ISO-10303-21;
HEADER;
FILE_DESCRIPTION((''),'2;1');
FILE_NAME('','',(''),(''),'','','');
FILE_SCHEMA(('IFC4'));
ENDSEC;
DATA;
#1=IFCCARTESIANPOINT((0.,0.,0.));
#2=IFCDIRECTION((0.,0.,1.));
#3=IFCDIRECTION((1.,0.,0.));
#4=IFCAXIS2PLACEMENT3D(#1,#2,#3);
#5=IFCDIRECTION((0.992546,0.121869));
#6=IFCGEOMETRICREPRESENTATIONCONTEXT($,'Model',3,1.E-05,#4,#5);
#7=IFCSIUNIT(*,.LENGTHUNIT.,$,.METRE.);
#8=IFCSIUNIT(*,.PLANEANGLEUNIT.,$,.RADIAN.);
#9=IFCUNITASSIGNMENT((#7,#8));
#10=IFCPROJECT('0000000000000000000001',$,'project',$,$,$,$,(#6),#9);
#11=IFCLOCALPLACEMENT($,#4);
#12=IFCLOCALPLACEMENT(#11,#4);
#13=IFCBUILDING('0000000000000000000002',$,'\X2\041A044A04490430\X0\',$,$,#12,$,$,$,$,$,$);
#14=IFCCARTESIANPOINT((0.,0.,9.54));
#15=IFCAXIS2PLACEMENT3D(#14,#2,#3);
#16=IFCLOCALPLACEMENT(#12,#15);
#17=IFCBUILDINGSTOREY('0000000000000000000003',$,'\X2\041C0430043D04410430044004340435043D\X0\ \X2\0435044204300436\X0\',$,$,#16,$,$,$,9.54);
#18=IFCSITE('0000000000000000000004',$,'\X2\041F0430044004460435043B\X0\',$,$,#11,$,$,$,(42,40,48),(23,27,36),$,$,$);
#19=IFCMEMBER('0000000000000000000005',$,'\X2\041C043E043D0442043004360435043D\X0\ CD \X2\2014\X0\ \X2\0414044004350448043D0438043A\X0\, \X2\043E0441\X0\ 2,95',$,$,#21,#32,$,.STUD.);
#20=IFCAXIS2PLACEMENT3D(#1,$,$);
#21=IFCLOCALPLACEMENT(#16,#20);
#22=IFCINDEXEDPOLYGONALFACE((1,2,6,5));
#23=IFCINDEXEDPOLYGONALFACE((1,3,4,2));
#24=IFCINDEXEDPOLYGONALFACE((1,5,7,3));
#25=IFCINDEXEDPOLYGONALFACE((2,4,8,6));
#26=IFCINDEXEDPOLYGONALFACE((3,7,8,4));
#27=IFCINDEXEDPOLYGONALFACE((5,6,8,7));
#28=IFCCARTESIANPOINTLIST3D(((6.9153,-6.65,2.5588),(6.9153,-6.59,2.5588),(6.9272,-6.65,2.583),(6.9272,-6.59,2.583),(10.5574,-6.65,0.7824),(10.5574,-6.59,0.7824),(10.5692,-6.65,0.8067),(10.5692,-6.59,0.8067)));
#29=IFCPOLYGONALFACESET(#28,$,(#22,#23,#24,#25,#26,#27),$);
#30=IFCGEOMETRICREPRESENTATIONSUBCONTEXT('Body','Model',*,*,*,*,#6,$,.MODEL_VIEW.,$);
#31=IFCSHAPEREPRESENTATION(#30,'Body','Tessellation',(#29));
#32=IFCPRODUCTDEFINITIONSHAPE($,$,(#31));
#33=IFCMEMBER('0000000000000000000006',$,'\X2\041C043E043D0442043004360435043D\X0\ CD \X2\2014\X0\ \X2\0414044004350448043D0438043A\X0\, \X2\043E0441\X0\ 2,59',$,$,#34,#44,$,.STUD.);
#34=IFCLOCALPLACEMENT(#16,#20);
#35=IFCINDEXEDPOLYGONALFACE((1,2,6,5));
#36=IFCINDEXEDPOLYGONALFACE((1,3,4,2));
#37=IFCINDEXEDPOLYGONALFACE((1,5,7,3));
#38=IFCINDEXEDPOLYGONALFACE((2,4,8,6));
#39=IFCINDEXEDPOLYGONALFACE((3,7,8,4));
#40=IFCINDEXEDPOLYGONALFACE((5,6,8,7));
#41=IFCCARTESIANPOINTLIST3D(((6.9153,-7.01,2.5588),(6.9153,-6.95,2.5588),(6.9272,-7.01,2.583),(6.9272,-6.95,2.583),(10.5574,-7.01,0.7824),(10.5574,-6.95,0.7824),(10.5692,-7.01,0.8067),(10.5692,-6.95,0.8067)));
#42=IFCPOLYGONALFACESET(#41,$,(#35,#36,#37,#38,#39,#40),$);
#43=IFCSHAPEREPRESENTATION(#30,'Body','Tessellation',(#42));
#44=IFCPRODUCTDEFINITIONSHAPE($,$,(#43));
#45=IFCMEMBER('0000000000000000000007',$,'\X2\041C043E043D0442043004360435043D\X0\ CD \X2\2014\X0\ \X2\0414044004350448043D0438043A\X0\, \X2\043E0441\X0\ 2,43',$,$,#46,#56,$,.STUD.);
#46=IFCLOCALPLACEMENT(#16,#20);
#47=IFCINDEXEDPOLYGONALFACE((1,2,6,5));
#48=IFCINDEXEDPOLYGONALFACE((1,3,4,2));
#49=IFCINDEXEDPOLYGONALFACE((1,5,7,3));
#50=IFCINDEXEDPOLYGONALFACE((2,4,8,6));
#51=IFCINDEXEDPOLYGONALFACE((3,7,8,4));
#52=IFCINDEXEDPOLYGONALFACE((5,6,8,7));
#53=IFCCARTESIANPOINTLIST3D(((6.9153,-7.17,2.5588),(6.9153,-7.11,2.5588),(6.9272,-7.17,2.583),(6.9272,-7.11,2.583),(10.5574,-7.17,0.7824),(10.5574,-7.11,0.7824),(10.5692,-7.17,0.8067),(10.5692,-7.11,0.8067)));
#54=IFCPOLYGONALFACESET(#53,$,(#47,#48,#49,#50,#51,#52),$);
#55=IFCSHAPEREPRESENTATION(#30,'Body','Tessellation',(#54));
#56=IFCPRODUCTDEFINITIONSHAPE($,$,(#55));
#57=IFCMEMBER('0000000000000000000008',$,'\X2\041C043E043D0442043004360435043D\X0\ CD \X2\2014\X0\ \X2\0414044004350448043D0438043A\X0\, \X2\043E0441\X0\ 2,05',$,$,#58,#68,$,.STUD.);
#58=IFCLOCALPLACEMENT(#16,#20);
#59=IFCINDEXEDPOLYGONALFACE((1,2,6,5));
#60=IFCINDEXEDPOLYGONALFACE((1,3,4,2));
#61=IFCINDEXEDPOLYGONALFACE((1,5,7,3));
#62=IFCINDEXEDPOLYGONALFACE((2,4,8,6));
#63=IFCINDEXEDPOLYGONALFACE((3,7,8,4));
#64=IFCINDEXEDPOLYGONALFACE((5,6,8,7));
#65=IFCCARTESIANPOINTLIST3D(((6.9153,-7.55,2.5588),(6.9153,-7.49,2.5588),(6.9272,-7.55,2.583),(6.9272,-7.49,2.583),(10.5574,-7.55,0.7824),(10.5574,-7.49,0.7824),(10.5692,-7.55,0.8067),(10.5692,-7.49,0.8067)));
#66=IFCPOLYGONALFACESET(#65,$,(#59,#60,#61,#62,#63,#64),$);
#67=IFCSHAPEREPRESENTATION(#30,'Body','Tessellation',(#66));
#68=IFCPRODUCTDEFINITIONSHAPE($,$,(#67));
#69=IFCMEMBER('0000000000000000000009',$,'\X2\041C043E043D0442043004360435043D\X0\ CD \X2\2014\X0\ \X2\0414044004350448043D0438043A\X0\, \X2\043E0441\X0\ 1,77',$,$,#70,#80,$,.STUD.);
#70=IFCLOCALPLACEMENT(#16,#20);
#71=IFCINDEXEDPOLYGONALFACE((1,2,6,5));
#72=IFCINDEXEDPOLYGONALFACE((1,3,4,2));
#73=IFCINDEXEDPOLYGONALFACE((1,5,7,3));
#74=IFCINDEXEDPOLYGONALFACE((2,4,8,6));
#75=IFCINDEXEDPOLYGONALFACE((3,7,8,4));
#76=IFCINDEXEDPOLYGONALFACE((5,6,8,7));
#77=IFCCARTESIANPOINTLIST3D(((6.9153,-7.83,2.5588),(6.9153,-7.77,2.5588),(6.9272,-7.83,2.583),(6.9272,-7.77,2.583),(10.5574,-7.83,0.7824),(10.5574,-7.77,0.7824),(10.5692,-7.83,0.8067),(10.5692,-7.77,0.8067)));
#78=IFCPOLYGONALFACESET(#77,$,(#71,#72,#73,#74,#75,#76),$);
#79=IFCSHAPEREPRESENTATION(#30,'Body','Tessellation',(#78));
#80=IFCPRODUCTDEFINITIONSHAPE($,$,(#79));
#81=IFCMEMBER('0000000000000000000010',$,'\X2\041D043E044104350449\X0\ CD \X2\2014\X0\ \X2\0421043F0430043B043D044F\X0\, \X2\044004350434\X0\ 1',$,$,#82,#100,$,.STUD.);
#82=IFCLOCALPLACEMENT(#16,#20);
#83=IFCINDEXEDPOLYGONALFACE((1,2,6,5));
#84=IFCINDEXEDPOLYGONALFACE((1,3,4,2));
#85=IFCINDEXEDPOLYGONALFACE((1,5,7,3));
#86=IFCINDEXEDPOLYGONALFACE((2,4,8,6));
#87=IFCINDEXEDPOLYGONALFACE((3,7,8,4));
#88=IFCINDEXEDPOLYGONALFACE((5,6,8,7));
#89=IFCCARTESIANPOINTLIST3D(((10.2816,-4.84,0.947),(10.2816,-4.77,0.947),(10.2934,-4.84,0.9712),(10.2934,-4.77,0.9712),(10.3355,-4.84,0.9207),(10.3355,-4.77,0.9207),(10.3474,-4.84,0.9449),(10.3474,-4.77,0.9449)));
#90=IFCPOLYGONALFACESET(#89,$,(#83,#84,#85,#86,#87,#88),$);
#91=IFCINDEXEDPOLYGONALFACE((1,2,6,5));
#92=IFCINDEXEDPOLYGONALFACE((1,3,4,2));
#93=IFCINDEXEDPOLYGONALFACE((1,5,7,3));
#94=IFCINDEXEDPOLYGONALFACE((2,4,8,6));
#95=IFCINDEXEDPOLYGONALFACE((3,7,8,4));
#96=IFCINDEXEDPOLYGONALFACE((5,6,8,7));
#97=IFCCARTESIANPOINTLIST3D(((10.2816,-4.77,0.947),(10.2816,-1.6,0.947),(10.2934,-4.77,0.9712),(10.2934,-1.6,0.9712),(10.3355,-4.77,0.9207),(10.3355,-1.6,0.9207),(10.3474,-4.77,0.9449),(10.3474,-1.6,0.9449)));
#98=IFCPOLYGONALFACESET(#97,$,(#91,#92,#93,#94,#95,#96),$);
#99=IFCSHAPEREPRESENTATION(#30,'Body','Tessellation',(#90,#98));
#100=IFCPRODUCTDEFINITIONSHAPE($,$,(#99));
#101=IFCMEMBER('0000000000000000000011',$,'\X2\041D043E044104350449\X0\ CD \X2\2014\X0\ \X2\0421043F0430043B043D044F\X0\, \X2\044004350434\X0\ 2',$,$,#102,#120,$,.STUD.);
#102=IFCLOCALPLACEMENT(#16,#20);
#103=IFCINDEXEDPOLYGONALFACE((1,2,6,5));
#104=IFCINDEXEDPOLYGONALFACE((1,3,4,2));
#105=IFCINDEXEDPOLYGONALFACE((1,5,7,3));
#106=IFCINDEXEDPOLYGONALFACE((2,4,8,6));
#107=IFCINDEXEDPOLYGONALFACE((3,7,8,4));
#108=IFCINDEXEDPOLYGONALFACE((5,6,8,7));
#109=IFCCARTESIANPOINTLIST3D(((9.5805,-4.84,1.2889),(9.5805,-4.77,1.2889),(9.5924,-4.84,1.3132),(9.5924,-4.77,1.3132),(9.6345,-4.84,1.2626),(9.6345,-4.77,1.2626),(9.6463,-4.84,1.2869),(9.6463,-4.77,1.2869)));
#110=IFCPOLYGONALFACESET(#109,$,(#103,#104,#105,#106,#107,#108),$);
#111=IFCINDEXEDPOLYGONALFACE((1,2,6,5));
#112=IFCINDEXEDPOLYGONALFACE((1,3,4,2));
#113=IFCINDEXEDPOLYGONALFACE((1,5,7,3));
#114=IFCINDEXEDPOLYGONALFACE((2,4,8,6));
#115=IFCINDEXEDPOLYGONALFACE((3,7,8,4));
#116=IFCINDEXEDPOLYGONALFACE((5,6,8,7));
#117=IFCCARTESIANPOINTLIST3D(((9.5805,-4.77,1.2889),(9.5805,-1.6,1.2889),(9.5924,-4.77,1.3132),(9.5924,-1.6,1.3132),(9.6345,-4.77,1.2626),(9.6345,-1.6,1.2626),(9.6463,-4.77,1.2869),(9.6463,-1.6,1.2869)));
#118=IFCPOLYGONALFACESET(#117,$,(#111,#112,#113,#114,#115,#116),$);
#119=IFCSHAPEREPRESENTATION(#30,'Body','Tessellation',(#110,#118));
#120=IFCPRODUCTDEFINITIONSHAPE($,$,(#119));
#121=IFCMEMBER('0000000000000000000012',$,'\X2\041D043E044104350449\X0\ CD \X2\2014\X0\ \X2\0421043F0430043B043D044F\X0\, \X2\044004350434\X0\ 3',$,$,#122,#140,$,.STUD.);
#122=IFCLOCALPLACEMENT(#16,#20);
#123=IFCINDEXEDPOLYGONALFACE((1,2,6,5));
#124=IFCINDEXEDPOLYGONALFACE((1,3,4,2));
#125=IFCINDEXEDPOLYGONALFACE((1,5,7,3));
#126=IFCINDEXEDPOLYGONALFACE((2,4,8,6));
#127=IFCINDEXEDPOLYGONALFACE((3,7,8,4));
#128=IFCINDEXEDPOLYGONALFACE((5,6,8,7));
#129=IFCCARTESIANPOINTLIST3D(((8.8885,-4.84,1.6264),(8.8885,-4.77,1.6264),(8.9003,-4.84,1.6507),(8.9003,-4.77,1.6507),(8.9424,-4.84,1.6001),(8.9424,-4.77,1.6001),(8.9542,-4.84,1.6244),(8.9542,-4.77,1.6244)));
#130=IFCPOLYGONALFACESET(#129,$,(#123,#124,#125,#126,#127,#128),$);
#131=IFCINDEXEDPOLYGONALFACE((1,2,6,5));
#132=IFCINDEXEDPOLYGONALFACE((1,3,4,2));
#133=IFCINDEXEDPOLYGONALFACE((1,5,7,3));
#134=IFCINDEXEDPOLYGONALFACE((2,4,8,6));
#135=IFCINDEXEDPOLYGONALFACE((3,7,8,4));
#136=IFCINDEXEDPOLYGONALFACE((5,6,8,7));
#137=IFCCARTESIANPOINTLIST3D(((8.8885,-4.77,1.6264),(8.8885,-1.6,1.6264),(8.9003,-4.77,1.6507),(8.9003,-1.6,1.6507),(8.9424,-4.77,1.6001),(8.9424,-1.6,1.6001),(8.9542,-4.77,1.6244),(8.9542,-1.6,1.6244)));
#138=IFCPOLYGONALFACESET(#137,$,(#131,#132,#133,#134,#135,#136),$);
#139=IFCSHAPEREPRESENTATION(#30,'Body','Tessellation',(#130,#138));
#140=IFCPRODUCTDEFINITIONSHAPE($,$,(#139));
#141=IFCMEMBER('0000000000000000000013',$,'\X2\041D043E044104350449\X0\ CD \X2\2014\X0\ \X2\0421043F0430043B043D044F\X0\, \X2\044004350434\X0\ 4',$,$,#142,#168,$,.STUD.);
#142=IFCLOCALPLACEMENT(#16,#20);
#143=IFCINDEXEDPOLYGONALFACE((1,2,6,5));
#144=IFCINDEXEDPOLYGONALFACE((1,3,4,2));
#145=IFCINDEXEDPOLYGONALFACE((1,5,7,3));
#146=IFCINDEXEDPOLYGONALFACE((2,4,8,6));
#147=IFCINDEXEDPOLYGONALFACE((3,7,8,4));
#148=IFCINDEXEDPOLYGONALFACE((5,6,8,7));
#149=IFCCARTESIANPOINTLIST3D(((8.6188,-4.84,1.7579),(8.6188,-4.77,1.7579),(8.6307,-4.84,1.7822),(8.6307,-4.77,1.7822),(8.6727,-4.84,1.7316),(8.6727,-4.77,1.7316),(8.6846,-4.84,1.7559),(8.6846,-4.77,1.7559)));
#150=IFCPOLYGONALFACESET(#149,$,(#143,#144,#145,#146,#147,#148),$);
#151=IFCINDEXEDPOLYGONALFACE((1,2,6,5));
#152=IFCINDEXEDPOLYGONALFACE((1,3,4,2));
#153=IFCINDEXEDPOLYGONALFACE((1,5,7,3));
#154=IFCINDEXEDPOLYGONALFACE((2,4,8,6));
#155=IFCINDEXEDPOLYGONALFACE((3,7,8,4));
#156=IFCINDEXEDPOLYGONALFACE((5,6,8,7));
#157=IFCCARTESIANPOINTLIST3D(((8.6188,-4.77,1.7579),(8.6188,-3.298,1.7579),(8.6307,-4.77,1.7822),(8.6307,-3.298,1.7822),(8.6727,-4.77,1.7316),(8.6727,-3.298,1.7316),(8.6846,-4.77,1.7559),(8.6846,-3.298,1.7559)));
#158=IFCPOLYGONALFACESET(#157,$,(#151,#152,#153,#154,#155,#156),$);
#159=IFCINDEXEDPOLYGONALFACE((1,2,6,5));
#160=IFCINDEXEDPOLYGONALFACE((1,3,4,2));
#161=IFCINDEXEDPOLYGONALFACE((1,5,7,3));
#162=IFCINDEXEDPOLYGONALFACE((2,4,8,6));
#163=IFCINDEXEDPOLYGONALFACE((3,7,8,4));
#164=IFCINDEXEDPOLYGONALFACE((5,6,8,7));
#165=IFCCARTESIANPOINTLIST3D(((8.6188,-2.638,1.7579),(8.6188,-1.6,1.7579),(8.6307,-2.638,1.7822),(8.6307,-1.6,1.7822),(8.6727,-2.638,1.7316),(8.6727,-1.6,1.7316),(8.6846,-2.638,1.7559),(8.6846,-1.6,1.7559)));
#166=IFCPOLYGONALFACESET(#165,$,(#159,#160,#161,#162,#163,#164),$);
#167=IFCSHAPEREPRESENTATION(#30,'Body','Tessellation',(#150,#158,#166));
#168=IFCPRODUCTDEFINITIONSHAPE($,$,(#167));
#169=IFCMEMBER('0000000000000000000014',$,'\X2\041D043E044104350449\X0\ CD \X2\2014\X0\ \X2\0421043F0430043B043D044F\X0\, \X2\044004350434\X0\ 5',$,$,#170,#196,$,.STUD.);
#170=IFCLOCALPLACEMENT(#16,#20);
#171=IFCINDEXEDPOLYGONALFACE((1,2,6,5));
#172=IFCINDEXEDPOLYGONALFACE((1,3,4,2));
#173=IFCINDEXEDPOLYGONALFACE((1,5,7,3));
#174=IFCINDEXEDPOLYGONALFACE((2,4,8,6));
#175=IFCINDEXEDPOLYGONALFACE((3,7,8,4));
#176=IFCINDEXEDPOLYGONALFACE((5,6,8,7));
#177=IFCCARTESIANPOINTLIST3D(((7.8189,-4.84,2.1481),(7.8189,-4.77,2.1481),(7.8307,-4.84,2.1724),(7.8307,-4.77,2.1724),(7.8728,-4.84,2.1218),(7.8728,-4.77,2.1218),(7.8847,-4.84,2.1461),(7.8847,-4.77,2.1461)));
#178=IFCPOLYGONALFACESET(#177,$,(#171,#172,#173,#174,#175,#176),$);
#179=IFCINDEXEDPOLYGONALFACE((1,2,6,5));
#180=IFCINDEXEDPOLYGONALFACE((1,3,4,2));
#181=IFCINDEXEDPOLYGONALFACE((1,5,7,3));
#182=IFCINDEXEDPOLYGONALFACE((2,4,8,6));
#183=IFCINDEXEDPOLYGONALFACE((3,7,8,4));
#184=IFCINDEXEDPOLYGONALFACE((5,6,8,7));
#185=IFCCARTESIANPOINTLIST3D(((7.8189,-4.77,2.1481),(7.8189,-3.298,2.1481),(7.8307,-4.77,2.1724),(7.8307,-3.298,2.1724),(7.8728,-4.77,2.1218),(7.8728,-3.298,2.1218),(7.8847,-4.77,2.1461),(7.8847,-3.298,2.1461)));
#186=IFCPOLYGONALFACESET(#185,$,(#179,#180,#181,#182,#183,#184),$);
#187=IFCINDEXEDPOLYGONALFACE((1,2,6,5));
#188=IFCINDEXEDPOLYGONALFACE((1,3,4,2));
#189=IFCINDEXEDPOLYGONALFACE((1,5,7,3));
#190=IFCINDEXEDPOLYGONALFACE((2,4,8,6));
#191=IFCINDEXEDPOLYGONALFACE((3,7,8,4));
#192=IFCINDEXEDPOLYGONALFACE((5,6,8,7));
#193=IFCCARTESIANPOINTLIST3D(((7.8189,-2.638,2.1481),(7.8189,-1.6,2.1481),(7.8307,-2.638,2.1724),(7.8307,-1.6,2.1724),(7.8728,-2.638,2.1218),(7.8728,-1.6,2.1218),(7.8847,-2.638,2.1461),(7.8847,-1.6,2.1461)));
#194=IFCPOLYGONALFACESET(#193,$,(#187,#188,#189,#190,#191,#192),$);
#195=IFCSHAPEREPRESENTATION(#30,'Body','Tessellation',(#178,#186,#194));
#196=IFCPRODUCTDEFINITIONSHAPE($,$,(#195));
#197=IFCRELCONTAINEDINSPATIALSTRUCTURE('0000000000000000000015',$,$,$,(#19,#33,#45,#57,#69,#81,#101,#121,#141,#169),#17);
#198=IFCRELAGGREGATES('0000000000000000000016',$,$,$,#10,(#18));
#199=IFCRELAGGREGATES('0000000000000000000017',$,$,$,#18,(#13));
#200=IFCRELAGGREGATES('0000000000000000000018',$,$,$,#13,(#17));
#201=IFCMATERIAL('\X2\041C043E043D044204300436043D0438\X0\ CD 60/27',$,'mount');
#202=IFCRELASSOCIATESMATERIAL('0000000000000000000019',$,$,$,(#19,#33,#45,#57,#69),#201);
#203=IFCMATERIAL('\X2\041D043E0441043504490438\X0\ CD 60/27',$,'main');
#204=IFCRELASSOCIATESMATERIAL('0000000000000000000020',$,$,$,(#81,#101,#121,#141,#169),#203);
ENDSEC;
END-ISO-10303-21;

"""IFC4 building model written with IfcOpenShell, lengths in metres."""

from ifc_helpers import new_model, si_unit, direction, frame, origin_with_axes, place, context, subcontext, project, spatial, polyline, outline, extrude, material, element, save


model = new_model("IFC4")

# Units and contexts
model_context = context("Model", 3, precision=1e-05, world=origin_with_axes(), true_north=direction((0.992546, 0.121869)))
body_context = subcontext(model_context, "Body", "Model", "MODEL_VIEW")
ifc_project = project(units=[si_unit("LENGTHUNIT", "METRE"), si_unit("PLANEANGLEUNIT", "RADIAN")], contexts=[model_context])

# Site, building, storey
site_placement = place(None, origin_with_axes())
site = spatial("IfcSite", under=ifc_project, at=site_placement, Name="Парцел", RefLatitude=(42, 40, 48), RefLongitude=(23, 27, 36))
building_placement = place(site_placement, origin_with_axes())
building = spatial("IfcBuilding", under=site, at=building_placement, Name="Къща")
storey_placement = place(building_placement, frame((0.0, 0.0, 9.54), z_axis=(0.0, 0.0, 1.0), x_axis=(1.0, 0.0, 0.0)))
storey = spatial("IfcBuildingStorey", under=building, at=storey_placement, Name="Мансарден етаж", Elevation=9.54)

# Members
ifc_material_1 = material(Name="Монтажни CD 60/27", Category="mount")
member_1_placement = place(storey_placement, origin_with_axes())
element("IfcMember", 1, at=member_1_placement, inside=storey, material=ifc_material_1, Name="Монтажен CD — Дрешник, ос 2,95", PredefinedType="STUD", context=body_context, shape_type="SweptSolid", body=[
    extrude(outline(polyline([(10.5574, -0.7824), (6.9153, -2.5587), (6.9272, -2.583), (10.5692, -0.8067), (10.5574, -0.7824)])), frame((0.0, -6.65, 0.0), z_axis=(0.0, 1.0, 0.0), x_axis=(1.0, 0.0, 0.0)), (0.0, 0.0, 1.0), 0.06),
])
member_2_placement = place(storey_placement, origin_with_axes())
element("IfcMember", 2, at=member_2_placement, inside=storey, material=ifc_material_1, Name="Монтажен CD — Дрешник, ос 2,59", PredefinedType="STUD", context=body_context, shape_type="SweptSolid", body=[
    extrude(outline(polyline([(10.5574, -0.7824), (6.9153, -2.5587), (6.9272, -2.583), (10.5692, -0.8067), (10.5574, -0.7824)])), frame((0.0, -7.01, 0.0), z_axis=(0.0, 1.0, 0.0), x_axis=(1.0, 0.0, 0.0)), (0.0, 0.0, 1.0), 0.06),
])
member_3_placement = place(storey_placement, origin_with_axes())
element("IfcMember", 3, at=member_3_placement, inside=storey, material=ifc_material_1, Name="Монтажен CD — Дрешник, ос 2,43", PredefinedType="STUD", context=body_context, shape_type="SweptSolid", body=[
    extrude(outline(polyline([(10.5574, -0.7824), (6.9153, -2.5587), (6.9272, -2.583), (10.5692, -0.8067), (10.5574, -0.7824)])), frame((0.0, -7.17, 0.0), z_axis=(0.0, 1.0, 0.0), x_axis=(1.0, 0.0, 0.0)), (0.0, 0.0, 1.0), 0.06),
])
member_4_placement = place(storey_placement, origin_with_axes())
element("IfcMember", 4, at=member_4_placement, inside=storey, material=ifc_material_1, Name="Монтажен CD — Дрешник, ос 2,05", PredefinedType="STUD", context=body_context, shape_type="SweptSolid", body=[
    extrude(outline(polyline([(10.5574, -0.7824), (6.9153, -2.5587), (6.9272, -2.583), (10.5692, -0.8067), (10.5574, -0.7824)])), frame((0.0, -7.55, 0.0), z_axis=(0.0, 1.0, 0.0), x_axis=(1.0, 0.0, 0.0)), (0.0, 0.0, 1.0), 0.06),
])
member_5_placement = place(storey_placement, origin_with_axes())
element("IfcMember", 5, at=member_5_placement, inside=storey, material=ifc_material_1, Name="Монтажен CD — Дрешник, ос 1,77", PredefinedType="STUD", context=body_context, shape_type="SweptSolid", body=[
    extrude(outline(polyline([(10.5574, -0.7824), (6.9153, -2.5587), (6.9272, -2.583), (10.5692, -0.8067), (10.5574, -0.7824)])), frame((0.0, -7.83, 0.0), z_axis=(0.0, 1.0, 0.0), x_axis=(1.0, 0.0, 0.0)), (0.0, 0.0, 1.0), 0.06),
])
ifc_material_2 = material(Name="Носещи CD 60/27", Category="main")
member_6_placement = place(storey_placement, origin_with_axes())
element("IfcMember", 6, at=member_6_placement, inside=storey, material=ifc_material_2, Name="Носещ CD — Спалня, ред 1", PredefinedType="STUD", context=body_context, shape_type="SweptSolid", body=[
    extrude(outline(polyline([(10.3355, -0.9207), (10.2816, -0.947), (10.2934, -0.9712), (10.3474, -0.9449), (10.3355, -0.9207)])), frame((0.0, -4.84, 0.0), z_axis=(0.0, 1.0, 0.0), x_axis=(1.0, 0.0, 0.0)), (0.0, 0.0, 1.0), 0.07),
    extrude(outline(polyline([(10.3355, -0.9207), (10.2816, -0.947), (10.2934, -0.9712), (10.3474, -0.9449), (10.3355, -0.9207)])), frame((0.0, -4.77, 0.0), z_axis=(0.0, 1.0, 0.0), x_axis=(1.0, 0.0, 0.0)), (0.0, 0.0, 1.0), 3.17),
])
member_7_placement = place(storey_placement, origin_with_axes())
element("IfcMember", 7, at=member_7_placement, inside=storey, material=ifc_material_2, Name="Носещ CD — Спалня, ред 2", PredefinedType="STUD", context=body_context, shape_type="SweptSolid", body=[
    extrude(outline(polyline([(9.6345, -1.2626), (9.5805, -1.2889), (9.5924, -1.3132), (9.6463, -1.2869), (9.6345, -1.2626)])), frame((0.0, -4.84, 0.0), z_axis=(0.0, 1.0, 0.0), x_axis=(1.0, 0.0, 0.0)), (0.0, 0.0, 1.0), 0.07),
    extrude(outline(polyline([(9.6345, -1.2626), (9.5805, -1.2889), (9.5924, -1.3132), (9.6463, -1.2869), (9.6345, -1.2626)])), frame((0.0, -4.77, 0.0), z_axis=(0.0, 1.0, 0.0), x_axis=(1.0, 0.0, 0.0)), (0.0, 0.0, 1.0), 3.17),
])
member_8_placement = place(storey_placement, origin_with_axes())
element("IfcMember", 8, at=member_8_placement, inside=storey, material=ifc_material_2, Name="Носещ CD — Спалня, ред 3", PredefinedType="STUD", context=body_context, shape_type="SweptSolid", body=[
    extrude(outline(polyline([(8.9424, -1.6001), (8.8885, -1.6264), (8.9003, -1.6507), (8.9542, -1.6244), (8.9424, -1.6001)])), frame((0.0, -4.84, 0.0), z_axis=(0.0, 1.0, 0.0), x_axis=(1.0, 0.0, 0.0)), (0.0, 0.0, 1.0), 0.07),
    extrude(outline(polyline([(8.9424, -1.6001), (8.8885, -1.6264), (8.9003, -1.6507), (8.9542, -1.6244), (8.9424, -1.6001)])), frame((0.0, -4.77, 0.0), z_axis=(0.0, 1.0, 0.0), x_axis=(1.0, 0.0, 0.0)), (0.0, 0.0, 1.0), 3.17),
])
member_9_placement = place(storey_placement, origin_with_axes())
element("IfcMember", 9, at=member_9_placement, inside=storey, material=ifc_material_2, Name="Носещ CD — Спалня, ред 4", PredefinedType="STUD", context=body_context, shape_type="SweptSolid", body=[
    extrude(outline(polyline([(8.6727, -1.7316), (8.6188, -1.7579), (8.6307, -1.7822), (8.6846, -1.7559), (8.6727, -1.7316)])), frame((0.0, -4.84, 0.0), z_axis=(0.0, 1.0, 0.0), x_axis=(1.0, 0.0, 0.0)), (0.0, 0.0, 1.0), 0.07),
    extrude(outline(polyline([(8.6727, -1.7316), (8.6188, -1.7579), (8.6307, -1.7822), (8.6846, -1.7559), (8.6727, -1.7316)])), frame((0.0, -4.77, 0.0), z_axis=(0.0, 1.0, 0.0), x_axis=(1.0, 0.0, 0.0)), (0.0, 0.0, 1.0), 1.472),
    extrude(outline(polyline([(8.6727, -1.7316), (8.6188, -1.7579), (8.6307, -1.7822), (8.6846, -1.7559), (8.6727, -1.7316)])), frame((0.0, -2.638, 0.0), z_axis=(0.0, 1.0, 0.0), x_axis=(1.0, 0.0, 0.0)), (0.0, 0.0, 1.0), 1.038),
])
member_10_placement = place(storey_placement, origin_with_axes())
element("IfcMember", 10, at=member_10_placement, inside=storey, material=ifc_material_2, Name="Носещ CD — Спалня, ред 5", PredefinedType="STUD", context=body_context, shape_type="SweptSolid", body=[
    extrude(outline(polyline([(7.8728, -2.1218), (7.8189, -2.1481), (7.8307, -2.1724), (7.8847, -2.1461), (7.8728, -2.1218)])), frame((0.0, -4.84, 0.0), z_axis=(0.0, 1.0, 0.0), x_axis=(1.0, 0.0, 0.0)), (0.0, 0.0, 1.0), 0.07),
    extrude(outline(polyline([(7.8728, -2.1218), (7.8189, -2.1481), (7.8307, -2.1724), (7.8847, -2.1461), (7.8728, -2.1218)])), frame((0.0, -4.77, 0.0), z_axis=(0.0, 1.0, 0.0), x_axis=(1.0, 0.0, 0.0)), (0.0, 0.0, 1.0), 1.472),
    extrude(outline(polyline([(7.8728, -2.1218), (7.8189, -2.1481), (7.8307, -2.1724), (7.8847, -2.1461), (7.8728, -2.1218)])), frame((0.0, -2.638, 0.0), z_axis=(0.0, 1.0, 0.0), x_axis=(1.0, 0.0, 0.0)), (0.0, 0.0, 1.0), 1.038),
])

save(model, "model.ifc")
